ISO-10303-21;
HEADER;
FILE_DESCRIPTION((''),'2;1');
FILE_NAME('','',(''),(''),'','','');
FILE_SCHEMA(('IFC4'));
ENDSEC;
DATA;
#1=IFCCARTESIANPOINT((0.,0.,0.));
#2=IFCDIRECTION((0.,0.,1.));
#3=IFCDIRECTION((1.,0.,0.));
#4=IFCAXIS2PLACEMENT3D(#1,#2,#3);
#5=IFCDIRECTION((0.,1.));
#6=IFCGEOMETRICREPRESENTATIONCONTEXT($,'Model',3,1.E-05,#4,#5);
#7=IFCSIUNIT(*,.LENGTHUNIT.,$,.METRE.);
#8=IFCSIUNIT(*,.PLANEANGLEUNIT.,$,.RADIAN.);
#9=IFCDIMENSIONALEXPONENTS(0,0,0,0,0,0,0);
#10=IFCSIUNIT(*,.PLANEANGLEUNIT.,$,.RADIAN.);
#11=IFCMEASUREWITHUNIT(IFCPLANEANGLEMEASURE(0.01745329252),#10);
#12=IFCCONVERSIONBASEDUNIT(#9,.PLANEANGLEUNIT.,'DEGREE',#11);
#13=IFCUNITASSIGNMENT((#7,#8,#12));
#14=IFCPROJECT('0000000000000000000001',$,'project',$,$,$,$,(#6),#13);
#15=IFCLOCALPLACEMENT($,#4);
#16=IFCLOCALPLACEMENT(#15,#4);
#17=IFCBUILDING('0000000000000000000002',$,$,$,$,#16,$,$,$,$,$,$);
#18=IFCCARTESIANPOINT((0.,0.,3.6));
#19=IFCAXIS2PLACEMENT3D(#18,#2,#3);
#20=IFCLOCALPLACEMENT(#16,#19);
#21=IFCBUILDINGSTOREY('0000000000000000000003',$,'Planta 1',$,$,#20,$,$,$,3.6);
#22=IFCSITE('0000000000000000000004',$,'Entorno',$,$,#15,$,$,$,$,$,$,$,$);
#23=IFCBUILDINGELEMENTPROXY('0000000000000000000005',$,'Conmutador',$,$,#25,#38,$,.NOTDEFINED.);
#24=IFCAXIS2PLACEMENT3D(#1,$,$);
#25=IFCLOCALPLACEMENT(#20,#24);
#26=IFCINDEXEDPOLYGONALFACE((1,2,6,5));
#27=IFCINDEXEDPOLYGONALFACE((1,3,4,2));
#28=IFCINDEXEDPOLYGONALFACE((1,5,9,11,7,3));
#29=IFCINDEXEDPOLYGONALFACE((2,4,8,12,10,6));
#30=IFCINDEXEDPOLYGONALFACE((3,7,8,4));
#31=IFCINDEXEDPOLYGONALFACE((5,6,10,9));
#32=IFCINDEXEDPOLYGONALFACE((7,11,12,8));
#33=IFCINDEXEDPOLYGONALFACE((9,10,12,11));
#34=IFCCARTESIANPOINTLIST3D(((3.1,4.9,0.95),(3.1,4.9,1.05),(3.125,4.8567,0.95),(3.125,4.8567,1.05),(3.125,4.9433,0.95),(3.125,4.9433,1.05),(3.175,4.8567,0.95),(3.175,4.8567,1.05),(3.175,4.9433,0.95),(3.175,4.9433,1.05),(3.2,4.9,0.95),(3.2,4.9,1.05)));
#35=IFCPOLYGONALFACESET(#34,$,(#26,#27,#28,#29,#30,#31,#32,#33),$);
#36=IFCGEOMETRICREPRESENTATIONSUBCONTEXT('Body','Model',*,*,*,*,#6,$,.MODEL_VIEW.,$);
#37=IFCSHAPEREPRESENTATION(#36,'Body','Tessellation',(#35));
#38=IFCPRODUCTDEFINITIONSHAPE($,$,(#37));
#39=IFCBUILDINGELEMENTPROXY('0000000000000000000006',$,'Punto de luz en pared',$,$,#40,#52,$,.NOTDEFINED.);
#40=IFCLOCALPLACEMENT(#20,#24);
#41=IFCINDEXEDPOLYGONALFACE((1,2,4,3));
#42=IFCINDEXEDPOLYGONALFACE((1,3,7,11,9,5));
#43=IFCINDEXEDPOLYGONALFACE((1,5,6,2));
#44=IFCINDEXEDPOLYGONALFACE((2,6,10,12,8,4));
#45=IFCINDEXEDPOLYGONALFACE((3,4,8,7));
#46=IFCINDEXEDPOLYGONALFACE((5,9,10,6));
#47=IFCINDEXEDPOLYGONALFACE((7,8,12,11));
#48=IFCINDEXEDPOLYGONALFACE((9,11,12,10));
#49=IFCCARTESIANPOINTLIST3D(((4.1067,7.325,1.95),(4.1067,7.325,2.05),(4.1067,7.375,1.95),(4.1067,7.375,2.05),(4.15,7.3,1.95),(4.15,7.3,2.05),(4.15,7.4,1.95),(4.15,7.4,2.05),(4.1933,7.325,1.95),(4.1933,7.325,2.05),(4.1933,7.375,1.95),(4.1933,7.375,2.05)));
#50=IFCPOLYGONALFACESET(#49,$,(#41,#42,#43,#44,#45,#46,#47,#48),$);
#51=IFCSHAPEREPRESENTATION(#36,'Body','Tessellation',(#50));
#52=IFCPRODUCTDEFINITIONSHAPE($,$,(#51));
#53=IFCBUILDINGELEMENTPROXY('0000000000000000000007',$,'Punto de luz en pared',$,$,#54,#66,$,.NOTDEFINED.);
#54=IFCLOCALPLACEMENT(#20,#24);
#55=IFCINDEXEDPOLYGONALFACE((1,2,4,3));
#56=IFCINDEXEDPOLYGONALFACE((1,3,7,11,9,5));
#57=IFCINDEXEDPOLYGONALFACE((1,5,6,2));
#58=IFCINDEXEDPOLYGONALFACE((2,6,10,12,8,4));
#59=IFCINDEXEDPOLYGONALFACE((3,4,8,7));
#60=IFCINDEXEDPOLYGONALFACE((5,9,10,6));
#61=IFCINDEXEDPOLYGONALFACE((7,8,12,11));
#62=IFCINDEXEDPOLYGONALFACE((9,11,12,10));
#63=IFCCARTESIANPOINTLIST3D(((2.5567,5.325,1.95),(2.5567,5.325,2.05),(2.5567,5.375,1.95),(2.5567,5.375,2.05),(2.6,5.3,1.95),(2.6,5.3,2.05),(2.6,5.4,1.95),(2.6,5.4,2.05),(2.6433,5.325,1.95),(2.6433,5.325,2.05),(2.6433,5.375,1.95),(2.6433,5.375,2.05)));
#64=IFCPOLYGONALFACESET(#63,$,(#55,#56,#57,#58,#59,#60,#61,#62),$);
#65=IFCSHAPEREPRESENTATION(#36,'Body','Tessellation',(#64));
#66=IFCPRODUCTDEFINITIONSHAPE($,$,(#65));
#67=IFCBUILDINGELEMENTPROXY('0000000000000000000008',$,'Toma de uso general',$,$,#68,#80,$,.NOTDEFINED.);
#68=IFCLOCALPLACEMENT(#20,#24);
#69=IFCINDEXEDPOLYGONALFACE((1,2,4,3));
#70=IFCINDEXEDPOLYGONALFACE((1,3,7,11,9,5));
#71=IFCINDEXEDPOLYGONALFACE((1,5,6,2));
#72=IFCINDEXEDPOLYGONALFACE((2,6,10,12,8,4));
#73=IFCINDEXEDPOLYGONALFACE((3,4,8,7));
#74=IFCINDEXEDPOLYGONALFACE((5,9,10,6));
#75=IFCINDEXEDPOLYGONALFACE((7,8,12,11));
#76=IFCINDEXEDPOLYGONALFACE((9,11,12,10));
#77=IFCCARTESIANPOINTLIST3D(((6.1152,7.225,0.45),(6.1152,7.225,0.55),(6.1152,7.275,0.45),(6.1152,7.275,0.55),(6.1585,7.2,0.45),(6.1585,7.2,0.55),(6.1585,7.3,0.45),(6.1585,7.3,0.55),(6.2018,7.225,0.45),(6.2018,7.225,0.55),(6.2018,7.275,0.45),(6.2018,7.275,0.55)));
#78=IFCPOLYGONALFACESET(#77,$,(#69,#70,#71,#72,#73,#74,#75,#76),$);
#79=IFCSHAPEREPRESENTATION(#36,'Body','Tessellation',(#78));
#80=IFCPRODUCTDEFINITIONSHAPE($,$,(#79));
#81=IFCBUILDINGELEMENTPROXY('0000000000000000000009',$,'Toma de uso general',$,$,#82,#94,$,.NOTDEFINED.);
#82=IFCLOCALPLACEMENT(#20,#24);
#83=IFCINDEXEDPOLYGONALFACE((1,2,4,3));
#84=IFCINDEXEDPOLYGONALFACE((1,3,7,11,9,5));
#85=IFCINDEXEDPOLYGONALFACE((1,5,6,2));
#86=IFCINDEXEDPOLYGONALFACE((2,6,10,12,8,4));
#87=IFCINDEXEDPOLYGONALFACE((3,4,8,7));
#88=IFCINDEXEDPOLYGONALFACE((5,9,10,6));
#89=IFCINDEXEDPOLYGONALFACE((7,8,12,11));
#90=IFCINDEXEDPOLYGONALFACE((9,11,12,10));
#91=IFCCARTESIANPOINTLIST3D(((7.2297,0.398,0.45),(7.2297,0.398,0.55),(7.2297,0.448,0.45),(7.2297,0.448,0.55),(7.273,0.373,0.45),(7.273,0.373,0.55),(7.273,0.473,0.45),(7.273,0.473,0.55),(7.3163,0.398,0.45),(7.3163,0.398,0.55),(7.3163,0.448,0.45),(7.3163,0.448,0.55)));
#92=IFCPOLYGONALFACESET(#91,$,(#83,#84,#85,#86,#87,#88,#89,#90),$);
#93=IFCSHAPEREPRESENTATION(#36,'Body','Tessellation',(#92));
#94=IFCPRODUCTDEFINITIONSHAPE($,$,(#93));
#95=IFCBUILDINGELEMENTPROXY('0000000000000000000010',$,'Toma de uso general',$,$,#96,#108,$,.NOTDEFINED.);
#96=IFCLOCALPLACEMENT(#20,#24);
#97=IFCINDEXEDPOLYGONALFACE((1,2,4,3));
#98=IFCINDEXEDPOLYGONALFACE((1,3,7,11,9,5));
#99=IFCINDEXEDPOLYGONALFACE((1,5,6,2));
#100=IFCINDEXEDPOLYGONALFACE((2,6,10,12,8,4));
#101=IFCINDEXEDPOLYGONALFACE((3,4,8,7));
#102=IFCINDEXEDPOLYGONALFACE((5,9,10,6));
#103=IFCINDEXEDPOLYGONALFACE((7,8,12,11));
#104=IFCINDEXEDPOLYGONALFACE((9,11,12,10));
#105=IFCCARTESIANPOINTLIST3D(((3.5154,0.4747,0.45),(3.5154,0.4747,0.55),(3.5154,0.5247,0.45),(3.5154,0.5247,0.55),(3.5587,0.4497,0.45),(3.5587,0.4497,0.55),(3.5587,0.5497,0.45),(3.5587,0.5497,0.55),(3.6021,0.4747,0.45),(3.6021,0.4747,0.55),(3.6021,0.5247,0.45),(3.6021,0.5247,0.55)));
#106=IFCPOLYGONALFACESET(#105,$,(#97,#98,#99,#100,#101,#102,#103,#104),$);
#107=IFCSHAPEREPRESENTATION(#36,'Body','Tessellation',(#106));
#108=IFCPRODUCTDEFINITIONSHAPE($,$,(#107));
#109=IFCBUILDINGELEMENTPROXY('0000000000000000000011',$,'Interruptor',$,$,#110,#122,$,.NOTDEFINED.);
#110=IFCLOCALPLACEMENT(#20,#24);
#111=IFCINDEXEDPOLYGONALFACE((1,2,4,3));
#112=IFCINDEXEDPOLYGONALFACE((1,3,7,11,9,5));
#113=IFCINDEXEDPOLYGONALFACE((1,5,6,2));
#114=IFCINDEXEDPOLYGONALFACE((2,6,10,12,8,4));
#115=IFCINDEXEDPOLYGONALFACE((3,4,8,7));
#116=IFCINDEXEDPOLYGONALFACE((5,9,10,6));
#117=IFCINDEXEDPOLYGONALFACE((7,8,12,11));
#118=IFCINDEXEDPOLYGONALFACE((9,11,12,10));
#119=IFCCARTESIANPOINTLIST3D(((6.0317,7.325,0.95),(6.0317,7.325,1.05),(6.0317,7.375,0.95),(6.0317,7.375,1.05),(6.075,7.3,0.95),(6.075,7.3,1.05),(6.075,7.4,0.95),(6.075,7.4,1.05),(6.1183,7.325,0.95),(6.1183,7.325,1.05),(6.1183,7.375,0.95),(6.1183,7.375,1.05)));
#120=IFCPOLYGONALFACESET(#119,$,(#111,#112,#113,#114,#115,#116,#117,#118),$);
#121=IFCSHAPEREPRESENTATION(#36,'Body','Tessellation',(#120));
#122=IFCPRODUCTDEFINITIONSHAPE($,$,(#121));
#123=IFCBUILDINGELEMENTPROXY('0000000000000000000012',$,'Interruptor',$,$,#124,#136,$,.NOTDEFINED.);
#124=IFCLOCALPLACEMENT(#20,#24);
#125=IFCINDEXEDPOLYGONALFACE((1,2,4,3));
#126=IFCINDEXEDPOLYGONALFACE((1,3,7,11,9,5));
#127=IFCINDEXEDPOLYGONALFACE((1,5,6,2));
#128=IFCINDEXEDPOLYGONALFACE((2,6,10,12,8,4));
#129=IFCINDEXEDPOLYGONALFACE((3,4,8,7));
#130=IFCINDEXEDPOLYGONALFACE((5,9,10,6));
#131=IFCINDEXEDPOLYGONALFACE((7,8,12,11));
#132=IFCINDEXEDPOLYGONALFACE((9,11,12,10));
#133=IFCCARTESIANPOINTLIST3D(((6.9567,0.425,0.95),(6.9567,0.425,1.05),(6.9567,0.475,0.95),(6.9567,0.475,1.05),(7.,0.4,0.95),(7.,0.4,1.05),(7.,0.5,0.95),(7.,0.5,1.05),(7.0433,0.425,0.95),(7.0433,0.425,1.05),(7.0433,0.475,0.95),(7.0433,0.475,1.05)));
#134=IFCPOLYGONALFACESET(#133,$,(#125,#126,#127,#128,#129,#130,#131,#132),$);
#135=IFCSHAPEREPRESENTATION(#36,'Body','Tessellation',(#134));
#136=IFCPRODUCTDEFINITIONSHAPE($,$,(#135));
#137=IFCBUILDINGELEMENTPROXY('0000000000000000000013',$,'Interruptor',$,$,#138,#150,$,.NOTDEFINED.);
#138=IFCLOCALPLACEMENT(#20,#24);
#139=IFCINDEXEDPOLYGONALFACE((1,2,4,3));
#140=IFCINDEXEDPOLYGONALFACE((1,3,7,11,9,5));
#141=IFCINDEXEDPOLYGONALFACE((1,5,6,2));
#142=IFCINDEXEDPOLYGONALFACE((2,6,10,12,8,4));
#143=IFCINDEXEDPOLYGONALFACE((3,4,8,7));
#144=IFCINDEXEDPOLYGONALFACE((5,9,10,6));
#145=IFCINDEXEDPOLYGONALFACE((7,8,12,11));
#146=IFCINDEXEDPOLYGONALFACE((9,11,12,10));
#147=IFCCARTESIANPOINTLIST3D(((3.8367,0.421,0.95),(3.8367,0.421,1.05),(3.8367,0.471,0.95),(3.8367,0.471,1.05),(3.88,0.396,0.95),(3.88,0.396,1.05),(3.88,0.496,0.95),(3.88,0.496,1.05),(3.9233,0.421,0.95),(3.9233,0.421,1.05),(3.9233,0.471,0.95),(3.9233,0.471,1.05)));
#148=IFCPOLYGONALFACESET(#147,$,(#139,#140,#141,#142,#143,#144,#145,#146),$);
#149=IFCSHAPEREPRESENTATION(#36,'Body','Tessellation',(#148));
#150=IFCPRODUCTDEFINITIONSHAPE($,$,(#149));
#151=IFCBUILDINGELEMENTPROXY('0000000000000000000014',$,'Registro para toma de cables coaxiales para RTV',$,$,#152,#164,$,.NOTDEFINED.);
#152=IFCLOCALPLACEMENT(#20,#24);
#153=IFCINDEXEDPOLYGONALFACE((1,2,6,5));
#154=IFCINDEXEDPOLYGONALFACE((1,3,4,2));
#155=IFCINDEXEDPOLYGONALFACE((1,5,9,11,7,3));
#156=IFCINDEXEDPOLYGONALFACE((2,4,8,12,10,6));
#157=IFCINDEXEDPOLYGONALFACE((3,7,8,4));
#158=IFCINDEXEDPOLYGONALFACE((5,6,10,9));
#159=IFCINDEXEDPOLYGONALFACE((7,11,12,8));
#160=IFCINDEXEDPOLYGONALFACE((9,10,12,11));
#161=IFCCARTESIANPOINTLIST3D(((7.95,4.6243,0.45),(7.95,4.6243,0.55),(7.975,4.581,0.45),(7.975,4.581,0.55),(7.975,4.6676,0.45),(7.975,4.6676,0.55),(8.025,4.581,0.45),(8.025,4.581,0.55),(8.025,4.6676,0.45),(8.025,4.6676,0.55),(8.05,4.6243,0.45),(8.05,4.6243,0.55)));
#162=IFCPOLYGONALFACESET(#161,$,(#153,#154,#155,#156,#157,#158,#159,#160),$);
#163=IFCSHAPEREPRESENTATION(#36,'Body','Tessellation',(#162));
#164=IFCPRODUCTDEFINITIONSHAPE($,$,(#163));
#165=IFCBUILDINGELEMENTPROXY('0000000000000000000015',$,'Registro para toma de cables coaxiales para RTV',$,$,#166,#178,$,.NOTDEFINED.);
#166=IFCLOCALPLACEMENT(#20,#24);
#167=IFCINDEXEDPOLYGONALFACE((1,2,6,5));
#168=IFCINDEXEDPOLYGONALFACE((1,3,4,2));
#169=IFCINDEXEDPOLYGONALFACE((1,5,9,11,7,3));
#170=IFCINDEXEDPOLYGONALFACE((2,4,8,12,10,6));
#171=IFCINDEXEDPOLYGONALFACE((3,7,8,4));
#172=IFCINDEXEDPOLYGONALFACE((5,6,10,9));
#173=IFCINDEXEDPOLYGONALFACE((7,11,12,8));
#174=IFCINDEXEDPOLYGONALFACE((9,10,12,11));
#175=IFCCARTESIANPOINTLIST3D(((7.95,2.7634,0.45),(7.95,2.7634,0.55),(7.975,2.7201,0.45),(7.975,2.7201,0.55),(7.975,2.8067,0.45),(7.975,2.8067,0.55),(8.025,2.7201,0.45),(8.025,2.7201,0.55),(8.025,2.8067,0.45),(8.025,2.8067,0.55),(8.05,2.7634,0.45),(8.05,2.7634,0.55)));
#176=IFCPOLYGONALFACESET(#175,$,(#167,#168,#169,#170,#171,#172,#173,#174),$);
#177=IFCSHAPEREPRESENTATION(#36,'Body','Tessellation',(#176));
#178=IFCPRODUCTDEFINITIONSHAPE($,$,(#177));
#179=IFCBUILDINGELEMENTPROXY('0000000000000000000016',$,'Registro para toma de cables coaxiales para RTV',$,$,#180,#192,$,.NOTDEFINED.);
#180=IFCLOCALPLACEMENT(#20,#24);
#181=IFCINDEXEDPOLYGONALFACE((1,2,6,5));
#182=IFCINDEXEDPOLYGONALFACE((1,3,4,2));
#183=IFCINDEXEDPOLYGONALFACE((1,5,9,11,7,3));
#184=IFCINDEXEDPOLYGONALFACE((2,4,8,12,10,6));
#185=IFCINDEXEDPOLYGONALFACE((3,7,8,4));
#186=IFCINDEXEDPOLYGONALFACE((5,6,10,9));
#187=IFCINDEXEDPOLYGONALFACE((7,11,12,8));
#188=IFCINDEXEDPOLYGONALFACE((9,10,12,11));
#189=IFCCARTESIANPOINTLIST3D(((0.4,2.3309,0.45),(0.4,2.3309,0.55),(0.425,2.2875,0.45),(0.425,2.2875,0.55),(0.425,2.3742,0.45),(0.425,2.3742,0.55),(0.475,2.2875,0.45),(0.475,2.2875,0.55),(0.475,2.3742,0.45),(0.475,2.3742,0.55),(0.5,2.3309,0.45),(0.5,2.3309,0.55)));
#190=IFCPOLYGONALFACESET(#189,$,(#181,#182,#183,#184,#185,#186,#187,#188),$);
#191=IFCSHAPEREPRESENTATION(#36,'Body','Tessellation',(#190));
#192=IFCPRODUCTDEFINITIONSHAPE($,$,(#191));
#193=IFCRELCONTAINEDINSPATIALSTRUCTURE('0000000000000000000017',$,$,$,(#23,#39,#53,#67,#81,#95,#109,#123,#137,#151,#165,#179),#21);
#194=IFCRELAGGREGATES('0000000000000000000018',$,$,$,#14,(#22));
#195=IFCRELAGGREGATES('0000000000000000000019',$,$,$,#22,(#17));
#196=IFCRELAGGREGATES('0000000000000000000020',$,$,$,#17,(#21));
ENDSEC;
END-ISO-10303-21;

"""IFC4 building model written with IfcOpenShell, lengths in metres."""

from ifc_helpers import new_model, entity, si_unit, converted_unit, direction, frame, origin_with_axes, place, context, subcontext, project, spatial, polyline, outline, extrude, source, transform, mapped, element, save


model = new_model("IFC4")

# Units and contexts
model_context = context("Model", 3, precision=1e-05, world=origin_with_axes(), true_north=direction((0.0, 1.0)))
body_context = subcontext(model_context, "Body", "Model", "MODEL_VIEW")
ifc_project = project(units=[si_unit("LENGTHUNIT", "METRE"), si_unit("PLANEANGLEUNIT", "RADIAN"), converted_unit("PLANEANGLEUNIT", "DEGREE", entity("IfcPlaneAngleMeasure", 0.01745329252), si_unit("PLANEANGLEUNIT", "RADIAN"), dimensions=[0, 0, 0, 0, 0, 0, 0])], contexts=[model_context])

# Site, building, storey
site_placement = place(None, origin_with_axes())
site = spatial("IfcSite", under=ifc_project, at=site_placement, Name="Entorno")
building_placement = place(site_placement, origin_with_axes())
building = spatial("IfcBuilding", under=site, at=building_placement)
storey_placement = place(building_placement, frame((0.0, 0.0, 3.6), z_axis=(0.0, 0.0, 1.0), x_axis=(1.0, 0.0, 0.0)))
storey = spatial("IfcBuildingStorey", under=building, at=storey_placement, Name="Planta 1", Elevation=3.6)

# Building element proxies
shared_shape_1 = source(origin_with_axes(), body_context, "Body", "SolidModel", [
    extrude(outline(polyline([(0.05, 0.0), (0.025, 0.0433), (-0.025, 0.0433), (-0.05, 0.0), (-0.025, -0.0433), (0.025, -0.0433), (0.05, 0.0)])), frame((0.0, 0.0, -0.05), z_axis=(0.0, 0.0, 1.0), x_axis=(1.0, 0.0, 0.0)), (0.0, 0.0, 1.0), 0.1),
])
proxy_1_placement = place(storey_placement, frame((0.0, 0.0, -3.6), z_axis=(0.0, 0.0, 1.0), x_axis=(1.0, 0.0, 0.0)))
element("IfcBuildingElementProxy", 1, at=proxy_1_placement, inside=storey, Name="Conmutador", PredefinedType="NOTDEFINED", context=body_context, shape_type="Brep", body=[
    mapped(shared_shape_1, transform((3.15, 4.9, 4.6), x_axis=(1.0, 0.0, 0.0), y_axis=(0.0, 1.0, 0.0), z_axis=(0.0, 0.0, 1.0))),
])
shared_shape_2 = source(origin_with_axes(), body_context, "Body", "SolidModel", [
    extrude(outline(polyline([(0.05, 0.0), (0.025, 0.0433), (-0.025, 0.0433), (-0.05, 0.0), (-0.025, -0.0433), (0.025, -0.0433), (0.05, 0.0)])), frame((0.0, 0.0, -0.05), z_axis=(0.0, 0.0, 1.0), x_axis=(1.0, 0.0, 0.0)), (0.0, 0.0, 1.0), 0.1),
])
proxy_2_placement = place(storey_placement, frame((0.0, 0.0, -3.6), z_axis=(0.0, 0.0, 1.0), x_axis=(1.0, 0.0, 0.0)))
element("IfcBuildingElementProxy", 2, at=proxy_2_placement, inside=storey, Name="Punto de luz en pared", PredefinedType="NOTDEFINED", context=body_context, shape_type="Brep", body=[
    mapped(shared_shape_2, transform((4.15, 7.35, 5.6), x_axis=(0.0, -1.0, 0.0), y_axis=(1.0, 0.0, 0.0), z_axis=(0.0, 0.0, 1.0))),
])
proxy_3_placement = place(storey_placement, frame((0.0, 0.0, -3.6), z_axis=(0.0, 0.0, 1.0), x_axis=(1.0, 0.0, 0.0)))
element("IfcBuildingElementProxy", 3, at=proxy_3_placement, inside=storey, Name="Punto de luz en pared", PredefinedType="NOTDEFINED", context=body_context, shape_type="Brep", body=[
    mapped(shared_shape_2, transform((2.6, 5.35, 5.6), x_axis=(0.0, -1.0, 0.0), y_axis=(1.0, 0.0, 0.0), z_axis=(0.0, 0.0, 1.0))),
])
shared_shape_3 = source(origin_with_axes(), body_context, "Body", "SolidModel", [
    extrude(outline(polyline([(0.05, 0.0), (0.025, 0.0433), (-0.025, 0.0433), (-0.05, 0.0), (-0.025, -0.0433), (0.025, -0.0433), (0.05, 0.0)])), frame((0.0, 0.0, -0.05), z_axis=(0.0, 0.0, 1.0), x_axis=(1.0, 0.0, 0.0)), (0.0, 0.0, 1.0), 0.1),
])
proxy_4_placement = place(storey_placement, frame((0.0, 0.0, -3.6), z_axis=(0.0, 0.0, 1.0), x_axis=(1.0, 0.0, 0.0)))
element("IfcBuildingElementProxy", 4, at=proxy_4_placement, inside=storey, Name="Toma de uso general", PredefinedType="NOTDEFINED", context=body_context, shape_type="Brep", body=[
    mapped(shared_shape_3, transform((6.1585, 7.25, 4.1), x_axis=(0.0, 1.0, 0.0), y_axis=(-1.0, 0.0, 0.0), z_axis=(0.0, 0.0, 1.0))),
])
proxy_5_placement = place(storey_placement, frame((0.0, 0.0, -3.6), z_axis=(0.0, 0.0, 1.0), x_axis=(1.0, 0.0, 0.0)))
element("IfcBuildingElementProxy", 5, at=proxy_5_placement, inside=storey, Name="Toma de uso general", PredefinedType="NOTDEFINED", context=body_context, shape_type="Brep", body=[
    mapped(shared_shape_3, transform((7.273, 0.423, 4.1), x_axis=(0.0, 1.0, 0.0), y_axis=(-1.0, 0.0, 0.0), z_axis=(0.0, 0.0, 1.0))),
])
proxy_6_placement = place(storey_placement, frame((0.0, 0.0, -3.6), z_axis=(0.0, 0.0, 1.0), x_axis=(1.0, 0.0, 0.0)))
element("IfcBuildingElementProxy", 6, at=proxy_6_placement, inside=storey, Name="Toma de uso general", PredefinedType="NOTDEFINED", context=body_context, shape_type="Brep", body=[
    mapped(shared_shape_3, transform((3.5587, 0.4997, 4.1), x_axis=(0.0, 1.0, 0.0), y_axis=(-1.0, 0.0, 0.0), z_axis=(0.0, 0.0, 1.0))),
])
shared_shape_4 = source(origin_with_axes(), body_context, "Body", "SolidModel", [
    extrude(outline(polyline([(0.05, 0.0), (0.025, 0.0433), (-0.025, 0.0433), (-0.05, 0.0), (-0.025, -0.0433), (0.025, -0.0433), (0.05, 0.0)])), frame((0.0, 0.0, -0.05), z_axis=(0.0, 0.0, 1.0), x_axis=(1.0, 0.0, 0.0)), (0.0, 0.0, 1.0), 0.1),
])
proxy_7_placement = place(storey_placement, frame((0.0, 0.0, -3.6), z_axis=(0.0, 0.0, 1.0), x_axis=(1.0, 0.0, 0.0)))
element("IfcBuildingElementProxy", 7, at=proxy_7_placement, inside=storey, Name="Interruptor", PredefinedType="NOTDEFINED", context=body_context, shape_type="Brep", body=[
    mapped(shared_shape_4, transform((6.075, 7.35, 4.6), x_axis=(0.0, 1.0, 0.0), y_axis=(-1.0, 0.0, 0.0), z_axis=(0.0, 0.0, 1.0))),
])
proxy_8_placement = place(storey_placement, frame((0.0, 0.0, -3.6), z_axis=(0.0, 0.0, 1.0), x_axis=(1.0, 0.0, 0.0)))
element("IfcBuildingElementProxy", 8, at=proxy_8_placement, inside=storey, Name="Interruptor", PredefinedType="NOTDEFINED", context=body_context, shape_type="Brep", body=[
    mapped(shared_shape_4, transform((7.0, 0.45, 4.6), x_axis=(0.0, 1.0, 0.0), y_axis=(-1.0, 0.0, 0.0), z_axis=(0.0, 0.0, 1.0))),
])
proxy_9_placement = place(storey_placement, frame((0.0, 0.0, -3.6), z_axis=(0.0, 0.0, 1.0), x_axis=(1.0, 0.0, 0.0)))
element("IfcBuildingElementProxy", 9, at=proxy_9_placement, inside=storey, Name="Interruptor", PredefinedType="NOTDEFINED", context=body_context, shape_type="Brep", body=[
    mapped(shared_shape_4, transform((3.88, 0.446, 4.6), x_axis=(0.0, 1.0, 0.0), y_axis=(-1.0, 0.0, 0.0), z_axis=(0.0, 0.0, 1.0))),
])
shared_shape_5 = source(origin_with_axes(), body_context, "Body", "SolidModel", [
    extrude(outline(polyline([(0.05, 0.0), (0.025, 0.0433), (-0.025, 0.0433), (-0.05, 0.0), (-0.025, -0.0433), (0.025, -0.0433), (0.05, 0.0)])), frame((0.0, 0.0, -0.05), z_axis=(0.0, 0.0, 1.0), x_axis=(1.0, 0.0, 0.0)), (0.0, 0.0, 1.0), 0.1),
])
proxy_10_placement = place(storey_placement, frame((0.0, 0.0, -3.6), z_axis=(0.0, 0.0, 1.0), x_axis=(1.0, 0.0, 0.0)))
element("IfcBuildingElementProxy", 10, at=proxy_10_placement, inside=storey, Name="Registro para toma de cables coaxiales para RTV", PredefinedType="NOTDEFINED", context=body_context, shape_type="Brep", body=[
    mapped(shared_shape_5, transform((8.0, 4.6243, 4.1), x_axis=(1.0, 0.0, 0.0), y_axis=(0.0, 1.0, 0.0), z_axis=(0.0, 0.0, 1.0))),
])
proxy_11_placement = place(storey_placement, frame((0.0, 0.0, -3.6), z_axis=(0.0, 0.0, 1.0), x_axis=(1.0, 0.0, 0.0)))
element("IfcBuildingElementProxy", 11, at=proxy_11_placement, inside=storey, Name="Registro para toma de cables coaxiales para RTV", PredefinedType="NOTDEFINED", context=body_context, shape_type="Brep", body=[
    mapped(shared_shape_5, transform((8.0, 2.7634, 4.1), x_axis=(1.0, 0.0, 0.0), y_axis=(0.0, 1.0, 0.0), z_axis=(0.0, 0.0, 1.0))),
])
proxy_12_placement = place(storey_placement, frame((0.0, 0.0, -3.6), z_axis=(0.0, 0.0, 1.0), x_axis=(1.0, 0.0, 0.0)))
element("IfcBuildingElementProxy", 12, at=proxy_12_placement, inside=storey, Name="Registro para toma de cables coaxiales para RTV", PredefinedType="NOTDEFINED", context=body_context, shape_type="Brep", body=[
    mapped(shared_shape_5, transform((0.45, 2.3309, 4.1), x_axis=(1.0, 0.0, 0.0), y_axis=(0.0, 1.0, 0.0), z_axis=(0.0, 0.0, 1.0))),
])

save(model, "model.ifc")
